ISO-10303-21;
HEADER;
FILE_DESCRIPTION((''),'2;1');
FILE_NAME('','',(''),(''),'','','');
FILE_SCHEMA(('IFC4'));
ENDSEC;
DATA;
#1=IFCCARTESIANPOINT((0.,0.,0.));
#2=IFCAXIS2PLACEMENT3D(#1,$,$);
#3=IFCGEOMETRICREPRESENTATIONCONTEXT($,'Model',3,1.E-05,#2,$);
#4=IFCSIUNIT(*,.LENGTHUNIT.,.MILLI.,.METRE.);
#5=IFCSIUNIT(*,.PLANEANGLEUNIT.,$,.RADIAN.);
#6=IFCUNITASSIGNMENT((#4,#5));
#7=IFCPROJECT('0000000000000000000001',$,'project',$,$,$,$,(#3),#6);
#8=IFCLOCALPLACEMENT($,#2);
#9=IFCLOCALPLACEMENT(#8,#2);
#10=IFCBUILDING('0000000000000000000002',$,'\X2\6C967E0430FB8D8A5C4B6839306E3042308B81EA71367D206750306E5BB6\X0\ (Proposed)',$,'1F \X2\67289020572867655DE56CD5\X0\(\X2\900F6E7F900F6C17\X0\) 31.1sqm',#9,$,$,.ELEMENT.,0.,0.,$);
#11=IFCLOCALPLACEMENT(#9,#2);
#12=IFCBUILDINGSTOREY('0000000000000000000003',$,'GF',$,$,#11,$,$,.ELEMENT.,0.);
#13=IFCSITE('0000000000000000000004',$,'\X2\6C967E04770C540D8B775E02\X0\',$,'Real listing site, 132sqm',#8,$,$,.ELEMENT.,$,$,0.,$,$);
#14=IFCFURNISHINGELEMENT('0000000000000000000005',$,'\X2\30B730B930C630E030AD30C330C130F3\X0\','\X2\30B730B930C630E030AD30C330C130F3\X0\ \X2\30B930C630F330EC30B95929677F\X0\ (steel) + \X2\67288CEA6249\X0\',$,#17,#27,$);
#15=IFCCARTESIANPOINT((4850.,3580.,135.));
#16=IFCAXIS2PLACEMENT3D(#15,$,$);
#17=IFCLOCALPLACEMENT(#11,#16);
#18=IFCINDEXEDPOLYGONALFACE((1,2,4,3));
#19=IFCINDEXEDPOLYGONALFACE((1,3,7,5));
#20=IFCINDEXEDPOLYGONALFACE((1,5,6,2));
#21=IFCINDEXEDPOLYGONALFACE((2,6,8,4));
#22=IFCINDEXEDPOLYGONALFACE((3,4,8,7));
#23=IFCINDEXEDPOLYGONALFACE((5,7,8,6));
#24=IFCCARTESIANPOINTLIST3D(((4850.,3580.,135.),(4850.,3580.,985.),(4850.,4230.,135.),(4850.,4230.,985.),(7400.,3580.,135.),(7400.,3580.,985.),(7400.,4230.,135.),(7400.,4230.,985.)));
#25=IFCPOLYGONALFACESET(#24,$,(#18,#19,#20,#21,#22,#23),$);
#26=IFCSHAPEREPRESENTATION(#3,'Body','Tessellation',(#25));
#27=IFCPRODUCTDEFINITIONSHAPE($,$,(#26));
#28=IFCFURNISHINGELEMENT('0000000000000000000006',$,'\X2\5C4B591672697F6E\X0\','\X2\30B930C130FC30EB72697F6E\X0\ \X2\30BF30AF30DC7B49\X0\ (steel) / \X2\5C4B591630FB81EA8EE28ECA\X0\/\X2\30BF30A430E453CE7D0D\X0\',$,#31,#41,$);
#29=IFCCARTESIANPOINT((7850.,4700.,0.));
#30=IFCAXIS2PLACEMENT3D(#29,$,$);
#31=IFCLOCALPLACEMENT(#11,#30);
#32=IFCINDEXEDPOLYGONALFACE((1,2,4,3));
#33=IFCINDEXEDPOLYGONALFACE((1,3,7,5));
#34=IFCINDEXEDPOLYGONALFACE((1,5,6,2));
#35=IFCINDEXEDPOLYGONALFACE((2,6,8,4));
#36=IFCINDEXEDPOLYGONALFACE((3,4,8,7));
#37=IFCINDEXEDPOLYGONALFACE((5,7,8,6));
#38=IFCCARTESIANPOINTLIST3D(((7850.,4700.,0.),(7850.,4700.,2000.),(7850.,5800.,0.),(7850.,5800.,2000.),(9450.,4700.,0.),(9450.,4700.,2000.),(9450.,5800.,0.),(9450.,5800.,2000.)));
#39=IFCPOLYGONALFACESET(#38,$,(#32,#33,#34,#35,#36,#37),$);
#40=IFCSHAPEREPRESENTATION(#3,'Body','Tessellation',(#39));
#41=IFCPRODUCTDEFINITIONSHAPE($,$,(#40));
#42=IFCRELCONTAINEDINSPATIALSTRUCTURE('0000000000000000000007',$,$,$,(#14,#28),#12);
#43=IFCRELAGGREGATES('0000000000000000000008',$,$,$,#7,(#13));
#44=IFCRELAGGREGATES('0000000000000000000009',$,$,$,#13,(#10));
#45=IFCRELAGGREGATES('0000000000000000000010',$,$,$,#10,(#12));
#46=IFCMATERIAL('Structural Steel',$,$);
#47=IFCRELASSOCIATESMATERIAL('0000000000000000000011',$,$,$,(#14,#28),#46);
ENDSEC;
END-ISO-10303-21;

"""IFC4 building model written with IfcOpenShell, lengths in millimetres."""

from ifc_helpers import new_model, si_unit, frame, frame_2d, origin, place, context, project, spatial, rectangle, extrude, material, element, save


model = new_model("IFC4")

# Units and contexts
model_context = context("Model", 3, precision=1e-05, world=origin())
ifc_project = project(units=[si_unit("LENGTHUNIT", "METRE", prefix="MILLI"), si_unit("PLANEANGLEUNIT", "RADIAN")], contexts=[model_context])

# Site, building, storey
site_placement = place(None, origin())
site = spatial("IfcSite", under=ifc_project, at=site_placement, Name="沖縄県名護市", ObjectType="Real listing site, 132sqm", CompositionType="ELEMENT", RefElevation=0.0)
building_placement = place(site_placement, origin())
building = spatial("IfcBuilding", under=site, at=building_placement, Name="沖縄・越屋根のある自然素材の家 (Proposed)", ObjectType="1F 木造在来工法(透湿透気) 31.1sqm", CompositionType="ELEMENT", ElevationOfRefHeight=0.0, ElevationOfTerrain=0.0)
storey_placement = place(building_placement, origin())
storey = spatial("IfcBuildingStorey", under=building, at=storey_placement, Name="GF", CompositionType="ELEMENT", Elevation=0.0)

# Shared definitions
ifc_material_1 = material(Name="Structural Steel")

# Furnishing elements
furnishing_1_placement = place(storey_placement, frame((4850.0, 3580.0, 135.0)))
element("IfcFurnishingElement", 1, at=furnishing_1_placement, inside=storey, material=ifc_material_1, Name="システムキッチン", Description="システムキッチン ステンレス天板 (steel) + 木質扉", context=model_context, shape_type="SweptSolid", body=[
    extrude(rectangle(XDim=2550.0, YDim=650.0, at=frame_2d((1275.0, 325.0))), frame((4850.0, 3580.0, 135.0)), (0.0, 0.0, 1.0), 850.0),
])
furnishing_2_placement = place(storey_placement, frame((7850.0, 4700.0, 0.0)))
element("IfcFurnishingElement", 2, at=furnishing_2_placement, inside=storey, material=ifc_material_1, Name="屋外物置", Description="スチール物置 タクボ等 (steel) / 屋外・自転車/タイヤ収納", context=model_context, shape_type="SweptSolid", body=[
    extrude(rectangle(XDim=1600.0, YDim=1100.0, at=frame_2d((800.0, 550.0))), frame((7850.0, 4700.0, 0.0)), (0.0, 0.0, 1.0), 2000.0),
])

save(model, "model.ifc")
